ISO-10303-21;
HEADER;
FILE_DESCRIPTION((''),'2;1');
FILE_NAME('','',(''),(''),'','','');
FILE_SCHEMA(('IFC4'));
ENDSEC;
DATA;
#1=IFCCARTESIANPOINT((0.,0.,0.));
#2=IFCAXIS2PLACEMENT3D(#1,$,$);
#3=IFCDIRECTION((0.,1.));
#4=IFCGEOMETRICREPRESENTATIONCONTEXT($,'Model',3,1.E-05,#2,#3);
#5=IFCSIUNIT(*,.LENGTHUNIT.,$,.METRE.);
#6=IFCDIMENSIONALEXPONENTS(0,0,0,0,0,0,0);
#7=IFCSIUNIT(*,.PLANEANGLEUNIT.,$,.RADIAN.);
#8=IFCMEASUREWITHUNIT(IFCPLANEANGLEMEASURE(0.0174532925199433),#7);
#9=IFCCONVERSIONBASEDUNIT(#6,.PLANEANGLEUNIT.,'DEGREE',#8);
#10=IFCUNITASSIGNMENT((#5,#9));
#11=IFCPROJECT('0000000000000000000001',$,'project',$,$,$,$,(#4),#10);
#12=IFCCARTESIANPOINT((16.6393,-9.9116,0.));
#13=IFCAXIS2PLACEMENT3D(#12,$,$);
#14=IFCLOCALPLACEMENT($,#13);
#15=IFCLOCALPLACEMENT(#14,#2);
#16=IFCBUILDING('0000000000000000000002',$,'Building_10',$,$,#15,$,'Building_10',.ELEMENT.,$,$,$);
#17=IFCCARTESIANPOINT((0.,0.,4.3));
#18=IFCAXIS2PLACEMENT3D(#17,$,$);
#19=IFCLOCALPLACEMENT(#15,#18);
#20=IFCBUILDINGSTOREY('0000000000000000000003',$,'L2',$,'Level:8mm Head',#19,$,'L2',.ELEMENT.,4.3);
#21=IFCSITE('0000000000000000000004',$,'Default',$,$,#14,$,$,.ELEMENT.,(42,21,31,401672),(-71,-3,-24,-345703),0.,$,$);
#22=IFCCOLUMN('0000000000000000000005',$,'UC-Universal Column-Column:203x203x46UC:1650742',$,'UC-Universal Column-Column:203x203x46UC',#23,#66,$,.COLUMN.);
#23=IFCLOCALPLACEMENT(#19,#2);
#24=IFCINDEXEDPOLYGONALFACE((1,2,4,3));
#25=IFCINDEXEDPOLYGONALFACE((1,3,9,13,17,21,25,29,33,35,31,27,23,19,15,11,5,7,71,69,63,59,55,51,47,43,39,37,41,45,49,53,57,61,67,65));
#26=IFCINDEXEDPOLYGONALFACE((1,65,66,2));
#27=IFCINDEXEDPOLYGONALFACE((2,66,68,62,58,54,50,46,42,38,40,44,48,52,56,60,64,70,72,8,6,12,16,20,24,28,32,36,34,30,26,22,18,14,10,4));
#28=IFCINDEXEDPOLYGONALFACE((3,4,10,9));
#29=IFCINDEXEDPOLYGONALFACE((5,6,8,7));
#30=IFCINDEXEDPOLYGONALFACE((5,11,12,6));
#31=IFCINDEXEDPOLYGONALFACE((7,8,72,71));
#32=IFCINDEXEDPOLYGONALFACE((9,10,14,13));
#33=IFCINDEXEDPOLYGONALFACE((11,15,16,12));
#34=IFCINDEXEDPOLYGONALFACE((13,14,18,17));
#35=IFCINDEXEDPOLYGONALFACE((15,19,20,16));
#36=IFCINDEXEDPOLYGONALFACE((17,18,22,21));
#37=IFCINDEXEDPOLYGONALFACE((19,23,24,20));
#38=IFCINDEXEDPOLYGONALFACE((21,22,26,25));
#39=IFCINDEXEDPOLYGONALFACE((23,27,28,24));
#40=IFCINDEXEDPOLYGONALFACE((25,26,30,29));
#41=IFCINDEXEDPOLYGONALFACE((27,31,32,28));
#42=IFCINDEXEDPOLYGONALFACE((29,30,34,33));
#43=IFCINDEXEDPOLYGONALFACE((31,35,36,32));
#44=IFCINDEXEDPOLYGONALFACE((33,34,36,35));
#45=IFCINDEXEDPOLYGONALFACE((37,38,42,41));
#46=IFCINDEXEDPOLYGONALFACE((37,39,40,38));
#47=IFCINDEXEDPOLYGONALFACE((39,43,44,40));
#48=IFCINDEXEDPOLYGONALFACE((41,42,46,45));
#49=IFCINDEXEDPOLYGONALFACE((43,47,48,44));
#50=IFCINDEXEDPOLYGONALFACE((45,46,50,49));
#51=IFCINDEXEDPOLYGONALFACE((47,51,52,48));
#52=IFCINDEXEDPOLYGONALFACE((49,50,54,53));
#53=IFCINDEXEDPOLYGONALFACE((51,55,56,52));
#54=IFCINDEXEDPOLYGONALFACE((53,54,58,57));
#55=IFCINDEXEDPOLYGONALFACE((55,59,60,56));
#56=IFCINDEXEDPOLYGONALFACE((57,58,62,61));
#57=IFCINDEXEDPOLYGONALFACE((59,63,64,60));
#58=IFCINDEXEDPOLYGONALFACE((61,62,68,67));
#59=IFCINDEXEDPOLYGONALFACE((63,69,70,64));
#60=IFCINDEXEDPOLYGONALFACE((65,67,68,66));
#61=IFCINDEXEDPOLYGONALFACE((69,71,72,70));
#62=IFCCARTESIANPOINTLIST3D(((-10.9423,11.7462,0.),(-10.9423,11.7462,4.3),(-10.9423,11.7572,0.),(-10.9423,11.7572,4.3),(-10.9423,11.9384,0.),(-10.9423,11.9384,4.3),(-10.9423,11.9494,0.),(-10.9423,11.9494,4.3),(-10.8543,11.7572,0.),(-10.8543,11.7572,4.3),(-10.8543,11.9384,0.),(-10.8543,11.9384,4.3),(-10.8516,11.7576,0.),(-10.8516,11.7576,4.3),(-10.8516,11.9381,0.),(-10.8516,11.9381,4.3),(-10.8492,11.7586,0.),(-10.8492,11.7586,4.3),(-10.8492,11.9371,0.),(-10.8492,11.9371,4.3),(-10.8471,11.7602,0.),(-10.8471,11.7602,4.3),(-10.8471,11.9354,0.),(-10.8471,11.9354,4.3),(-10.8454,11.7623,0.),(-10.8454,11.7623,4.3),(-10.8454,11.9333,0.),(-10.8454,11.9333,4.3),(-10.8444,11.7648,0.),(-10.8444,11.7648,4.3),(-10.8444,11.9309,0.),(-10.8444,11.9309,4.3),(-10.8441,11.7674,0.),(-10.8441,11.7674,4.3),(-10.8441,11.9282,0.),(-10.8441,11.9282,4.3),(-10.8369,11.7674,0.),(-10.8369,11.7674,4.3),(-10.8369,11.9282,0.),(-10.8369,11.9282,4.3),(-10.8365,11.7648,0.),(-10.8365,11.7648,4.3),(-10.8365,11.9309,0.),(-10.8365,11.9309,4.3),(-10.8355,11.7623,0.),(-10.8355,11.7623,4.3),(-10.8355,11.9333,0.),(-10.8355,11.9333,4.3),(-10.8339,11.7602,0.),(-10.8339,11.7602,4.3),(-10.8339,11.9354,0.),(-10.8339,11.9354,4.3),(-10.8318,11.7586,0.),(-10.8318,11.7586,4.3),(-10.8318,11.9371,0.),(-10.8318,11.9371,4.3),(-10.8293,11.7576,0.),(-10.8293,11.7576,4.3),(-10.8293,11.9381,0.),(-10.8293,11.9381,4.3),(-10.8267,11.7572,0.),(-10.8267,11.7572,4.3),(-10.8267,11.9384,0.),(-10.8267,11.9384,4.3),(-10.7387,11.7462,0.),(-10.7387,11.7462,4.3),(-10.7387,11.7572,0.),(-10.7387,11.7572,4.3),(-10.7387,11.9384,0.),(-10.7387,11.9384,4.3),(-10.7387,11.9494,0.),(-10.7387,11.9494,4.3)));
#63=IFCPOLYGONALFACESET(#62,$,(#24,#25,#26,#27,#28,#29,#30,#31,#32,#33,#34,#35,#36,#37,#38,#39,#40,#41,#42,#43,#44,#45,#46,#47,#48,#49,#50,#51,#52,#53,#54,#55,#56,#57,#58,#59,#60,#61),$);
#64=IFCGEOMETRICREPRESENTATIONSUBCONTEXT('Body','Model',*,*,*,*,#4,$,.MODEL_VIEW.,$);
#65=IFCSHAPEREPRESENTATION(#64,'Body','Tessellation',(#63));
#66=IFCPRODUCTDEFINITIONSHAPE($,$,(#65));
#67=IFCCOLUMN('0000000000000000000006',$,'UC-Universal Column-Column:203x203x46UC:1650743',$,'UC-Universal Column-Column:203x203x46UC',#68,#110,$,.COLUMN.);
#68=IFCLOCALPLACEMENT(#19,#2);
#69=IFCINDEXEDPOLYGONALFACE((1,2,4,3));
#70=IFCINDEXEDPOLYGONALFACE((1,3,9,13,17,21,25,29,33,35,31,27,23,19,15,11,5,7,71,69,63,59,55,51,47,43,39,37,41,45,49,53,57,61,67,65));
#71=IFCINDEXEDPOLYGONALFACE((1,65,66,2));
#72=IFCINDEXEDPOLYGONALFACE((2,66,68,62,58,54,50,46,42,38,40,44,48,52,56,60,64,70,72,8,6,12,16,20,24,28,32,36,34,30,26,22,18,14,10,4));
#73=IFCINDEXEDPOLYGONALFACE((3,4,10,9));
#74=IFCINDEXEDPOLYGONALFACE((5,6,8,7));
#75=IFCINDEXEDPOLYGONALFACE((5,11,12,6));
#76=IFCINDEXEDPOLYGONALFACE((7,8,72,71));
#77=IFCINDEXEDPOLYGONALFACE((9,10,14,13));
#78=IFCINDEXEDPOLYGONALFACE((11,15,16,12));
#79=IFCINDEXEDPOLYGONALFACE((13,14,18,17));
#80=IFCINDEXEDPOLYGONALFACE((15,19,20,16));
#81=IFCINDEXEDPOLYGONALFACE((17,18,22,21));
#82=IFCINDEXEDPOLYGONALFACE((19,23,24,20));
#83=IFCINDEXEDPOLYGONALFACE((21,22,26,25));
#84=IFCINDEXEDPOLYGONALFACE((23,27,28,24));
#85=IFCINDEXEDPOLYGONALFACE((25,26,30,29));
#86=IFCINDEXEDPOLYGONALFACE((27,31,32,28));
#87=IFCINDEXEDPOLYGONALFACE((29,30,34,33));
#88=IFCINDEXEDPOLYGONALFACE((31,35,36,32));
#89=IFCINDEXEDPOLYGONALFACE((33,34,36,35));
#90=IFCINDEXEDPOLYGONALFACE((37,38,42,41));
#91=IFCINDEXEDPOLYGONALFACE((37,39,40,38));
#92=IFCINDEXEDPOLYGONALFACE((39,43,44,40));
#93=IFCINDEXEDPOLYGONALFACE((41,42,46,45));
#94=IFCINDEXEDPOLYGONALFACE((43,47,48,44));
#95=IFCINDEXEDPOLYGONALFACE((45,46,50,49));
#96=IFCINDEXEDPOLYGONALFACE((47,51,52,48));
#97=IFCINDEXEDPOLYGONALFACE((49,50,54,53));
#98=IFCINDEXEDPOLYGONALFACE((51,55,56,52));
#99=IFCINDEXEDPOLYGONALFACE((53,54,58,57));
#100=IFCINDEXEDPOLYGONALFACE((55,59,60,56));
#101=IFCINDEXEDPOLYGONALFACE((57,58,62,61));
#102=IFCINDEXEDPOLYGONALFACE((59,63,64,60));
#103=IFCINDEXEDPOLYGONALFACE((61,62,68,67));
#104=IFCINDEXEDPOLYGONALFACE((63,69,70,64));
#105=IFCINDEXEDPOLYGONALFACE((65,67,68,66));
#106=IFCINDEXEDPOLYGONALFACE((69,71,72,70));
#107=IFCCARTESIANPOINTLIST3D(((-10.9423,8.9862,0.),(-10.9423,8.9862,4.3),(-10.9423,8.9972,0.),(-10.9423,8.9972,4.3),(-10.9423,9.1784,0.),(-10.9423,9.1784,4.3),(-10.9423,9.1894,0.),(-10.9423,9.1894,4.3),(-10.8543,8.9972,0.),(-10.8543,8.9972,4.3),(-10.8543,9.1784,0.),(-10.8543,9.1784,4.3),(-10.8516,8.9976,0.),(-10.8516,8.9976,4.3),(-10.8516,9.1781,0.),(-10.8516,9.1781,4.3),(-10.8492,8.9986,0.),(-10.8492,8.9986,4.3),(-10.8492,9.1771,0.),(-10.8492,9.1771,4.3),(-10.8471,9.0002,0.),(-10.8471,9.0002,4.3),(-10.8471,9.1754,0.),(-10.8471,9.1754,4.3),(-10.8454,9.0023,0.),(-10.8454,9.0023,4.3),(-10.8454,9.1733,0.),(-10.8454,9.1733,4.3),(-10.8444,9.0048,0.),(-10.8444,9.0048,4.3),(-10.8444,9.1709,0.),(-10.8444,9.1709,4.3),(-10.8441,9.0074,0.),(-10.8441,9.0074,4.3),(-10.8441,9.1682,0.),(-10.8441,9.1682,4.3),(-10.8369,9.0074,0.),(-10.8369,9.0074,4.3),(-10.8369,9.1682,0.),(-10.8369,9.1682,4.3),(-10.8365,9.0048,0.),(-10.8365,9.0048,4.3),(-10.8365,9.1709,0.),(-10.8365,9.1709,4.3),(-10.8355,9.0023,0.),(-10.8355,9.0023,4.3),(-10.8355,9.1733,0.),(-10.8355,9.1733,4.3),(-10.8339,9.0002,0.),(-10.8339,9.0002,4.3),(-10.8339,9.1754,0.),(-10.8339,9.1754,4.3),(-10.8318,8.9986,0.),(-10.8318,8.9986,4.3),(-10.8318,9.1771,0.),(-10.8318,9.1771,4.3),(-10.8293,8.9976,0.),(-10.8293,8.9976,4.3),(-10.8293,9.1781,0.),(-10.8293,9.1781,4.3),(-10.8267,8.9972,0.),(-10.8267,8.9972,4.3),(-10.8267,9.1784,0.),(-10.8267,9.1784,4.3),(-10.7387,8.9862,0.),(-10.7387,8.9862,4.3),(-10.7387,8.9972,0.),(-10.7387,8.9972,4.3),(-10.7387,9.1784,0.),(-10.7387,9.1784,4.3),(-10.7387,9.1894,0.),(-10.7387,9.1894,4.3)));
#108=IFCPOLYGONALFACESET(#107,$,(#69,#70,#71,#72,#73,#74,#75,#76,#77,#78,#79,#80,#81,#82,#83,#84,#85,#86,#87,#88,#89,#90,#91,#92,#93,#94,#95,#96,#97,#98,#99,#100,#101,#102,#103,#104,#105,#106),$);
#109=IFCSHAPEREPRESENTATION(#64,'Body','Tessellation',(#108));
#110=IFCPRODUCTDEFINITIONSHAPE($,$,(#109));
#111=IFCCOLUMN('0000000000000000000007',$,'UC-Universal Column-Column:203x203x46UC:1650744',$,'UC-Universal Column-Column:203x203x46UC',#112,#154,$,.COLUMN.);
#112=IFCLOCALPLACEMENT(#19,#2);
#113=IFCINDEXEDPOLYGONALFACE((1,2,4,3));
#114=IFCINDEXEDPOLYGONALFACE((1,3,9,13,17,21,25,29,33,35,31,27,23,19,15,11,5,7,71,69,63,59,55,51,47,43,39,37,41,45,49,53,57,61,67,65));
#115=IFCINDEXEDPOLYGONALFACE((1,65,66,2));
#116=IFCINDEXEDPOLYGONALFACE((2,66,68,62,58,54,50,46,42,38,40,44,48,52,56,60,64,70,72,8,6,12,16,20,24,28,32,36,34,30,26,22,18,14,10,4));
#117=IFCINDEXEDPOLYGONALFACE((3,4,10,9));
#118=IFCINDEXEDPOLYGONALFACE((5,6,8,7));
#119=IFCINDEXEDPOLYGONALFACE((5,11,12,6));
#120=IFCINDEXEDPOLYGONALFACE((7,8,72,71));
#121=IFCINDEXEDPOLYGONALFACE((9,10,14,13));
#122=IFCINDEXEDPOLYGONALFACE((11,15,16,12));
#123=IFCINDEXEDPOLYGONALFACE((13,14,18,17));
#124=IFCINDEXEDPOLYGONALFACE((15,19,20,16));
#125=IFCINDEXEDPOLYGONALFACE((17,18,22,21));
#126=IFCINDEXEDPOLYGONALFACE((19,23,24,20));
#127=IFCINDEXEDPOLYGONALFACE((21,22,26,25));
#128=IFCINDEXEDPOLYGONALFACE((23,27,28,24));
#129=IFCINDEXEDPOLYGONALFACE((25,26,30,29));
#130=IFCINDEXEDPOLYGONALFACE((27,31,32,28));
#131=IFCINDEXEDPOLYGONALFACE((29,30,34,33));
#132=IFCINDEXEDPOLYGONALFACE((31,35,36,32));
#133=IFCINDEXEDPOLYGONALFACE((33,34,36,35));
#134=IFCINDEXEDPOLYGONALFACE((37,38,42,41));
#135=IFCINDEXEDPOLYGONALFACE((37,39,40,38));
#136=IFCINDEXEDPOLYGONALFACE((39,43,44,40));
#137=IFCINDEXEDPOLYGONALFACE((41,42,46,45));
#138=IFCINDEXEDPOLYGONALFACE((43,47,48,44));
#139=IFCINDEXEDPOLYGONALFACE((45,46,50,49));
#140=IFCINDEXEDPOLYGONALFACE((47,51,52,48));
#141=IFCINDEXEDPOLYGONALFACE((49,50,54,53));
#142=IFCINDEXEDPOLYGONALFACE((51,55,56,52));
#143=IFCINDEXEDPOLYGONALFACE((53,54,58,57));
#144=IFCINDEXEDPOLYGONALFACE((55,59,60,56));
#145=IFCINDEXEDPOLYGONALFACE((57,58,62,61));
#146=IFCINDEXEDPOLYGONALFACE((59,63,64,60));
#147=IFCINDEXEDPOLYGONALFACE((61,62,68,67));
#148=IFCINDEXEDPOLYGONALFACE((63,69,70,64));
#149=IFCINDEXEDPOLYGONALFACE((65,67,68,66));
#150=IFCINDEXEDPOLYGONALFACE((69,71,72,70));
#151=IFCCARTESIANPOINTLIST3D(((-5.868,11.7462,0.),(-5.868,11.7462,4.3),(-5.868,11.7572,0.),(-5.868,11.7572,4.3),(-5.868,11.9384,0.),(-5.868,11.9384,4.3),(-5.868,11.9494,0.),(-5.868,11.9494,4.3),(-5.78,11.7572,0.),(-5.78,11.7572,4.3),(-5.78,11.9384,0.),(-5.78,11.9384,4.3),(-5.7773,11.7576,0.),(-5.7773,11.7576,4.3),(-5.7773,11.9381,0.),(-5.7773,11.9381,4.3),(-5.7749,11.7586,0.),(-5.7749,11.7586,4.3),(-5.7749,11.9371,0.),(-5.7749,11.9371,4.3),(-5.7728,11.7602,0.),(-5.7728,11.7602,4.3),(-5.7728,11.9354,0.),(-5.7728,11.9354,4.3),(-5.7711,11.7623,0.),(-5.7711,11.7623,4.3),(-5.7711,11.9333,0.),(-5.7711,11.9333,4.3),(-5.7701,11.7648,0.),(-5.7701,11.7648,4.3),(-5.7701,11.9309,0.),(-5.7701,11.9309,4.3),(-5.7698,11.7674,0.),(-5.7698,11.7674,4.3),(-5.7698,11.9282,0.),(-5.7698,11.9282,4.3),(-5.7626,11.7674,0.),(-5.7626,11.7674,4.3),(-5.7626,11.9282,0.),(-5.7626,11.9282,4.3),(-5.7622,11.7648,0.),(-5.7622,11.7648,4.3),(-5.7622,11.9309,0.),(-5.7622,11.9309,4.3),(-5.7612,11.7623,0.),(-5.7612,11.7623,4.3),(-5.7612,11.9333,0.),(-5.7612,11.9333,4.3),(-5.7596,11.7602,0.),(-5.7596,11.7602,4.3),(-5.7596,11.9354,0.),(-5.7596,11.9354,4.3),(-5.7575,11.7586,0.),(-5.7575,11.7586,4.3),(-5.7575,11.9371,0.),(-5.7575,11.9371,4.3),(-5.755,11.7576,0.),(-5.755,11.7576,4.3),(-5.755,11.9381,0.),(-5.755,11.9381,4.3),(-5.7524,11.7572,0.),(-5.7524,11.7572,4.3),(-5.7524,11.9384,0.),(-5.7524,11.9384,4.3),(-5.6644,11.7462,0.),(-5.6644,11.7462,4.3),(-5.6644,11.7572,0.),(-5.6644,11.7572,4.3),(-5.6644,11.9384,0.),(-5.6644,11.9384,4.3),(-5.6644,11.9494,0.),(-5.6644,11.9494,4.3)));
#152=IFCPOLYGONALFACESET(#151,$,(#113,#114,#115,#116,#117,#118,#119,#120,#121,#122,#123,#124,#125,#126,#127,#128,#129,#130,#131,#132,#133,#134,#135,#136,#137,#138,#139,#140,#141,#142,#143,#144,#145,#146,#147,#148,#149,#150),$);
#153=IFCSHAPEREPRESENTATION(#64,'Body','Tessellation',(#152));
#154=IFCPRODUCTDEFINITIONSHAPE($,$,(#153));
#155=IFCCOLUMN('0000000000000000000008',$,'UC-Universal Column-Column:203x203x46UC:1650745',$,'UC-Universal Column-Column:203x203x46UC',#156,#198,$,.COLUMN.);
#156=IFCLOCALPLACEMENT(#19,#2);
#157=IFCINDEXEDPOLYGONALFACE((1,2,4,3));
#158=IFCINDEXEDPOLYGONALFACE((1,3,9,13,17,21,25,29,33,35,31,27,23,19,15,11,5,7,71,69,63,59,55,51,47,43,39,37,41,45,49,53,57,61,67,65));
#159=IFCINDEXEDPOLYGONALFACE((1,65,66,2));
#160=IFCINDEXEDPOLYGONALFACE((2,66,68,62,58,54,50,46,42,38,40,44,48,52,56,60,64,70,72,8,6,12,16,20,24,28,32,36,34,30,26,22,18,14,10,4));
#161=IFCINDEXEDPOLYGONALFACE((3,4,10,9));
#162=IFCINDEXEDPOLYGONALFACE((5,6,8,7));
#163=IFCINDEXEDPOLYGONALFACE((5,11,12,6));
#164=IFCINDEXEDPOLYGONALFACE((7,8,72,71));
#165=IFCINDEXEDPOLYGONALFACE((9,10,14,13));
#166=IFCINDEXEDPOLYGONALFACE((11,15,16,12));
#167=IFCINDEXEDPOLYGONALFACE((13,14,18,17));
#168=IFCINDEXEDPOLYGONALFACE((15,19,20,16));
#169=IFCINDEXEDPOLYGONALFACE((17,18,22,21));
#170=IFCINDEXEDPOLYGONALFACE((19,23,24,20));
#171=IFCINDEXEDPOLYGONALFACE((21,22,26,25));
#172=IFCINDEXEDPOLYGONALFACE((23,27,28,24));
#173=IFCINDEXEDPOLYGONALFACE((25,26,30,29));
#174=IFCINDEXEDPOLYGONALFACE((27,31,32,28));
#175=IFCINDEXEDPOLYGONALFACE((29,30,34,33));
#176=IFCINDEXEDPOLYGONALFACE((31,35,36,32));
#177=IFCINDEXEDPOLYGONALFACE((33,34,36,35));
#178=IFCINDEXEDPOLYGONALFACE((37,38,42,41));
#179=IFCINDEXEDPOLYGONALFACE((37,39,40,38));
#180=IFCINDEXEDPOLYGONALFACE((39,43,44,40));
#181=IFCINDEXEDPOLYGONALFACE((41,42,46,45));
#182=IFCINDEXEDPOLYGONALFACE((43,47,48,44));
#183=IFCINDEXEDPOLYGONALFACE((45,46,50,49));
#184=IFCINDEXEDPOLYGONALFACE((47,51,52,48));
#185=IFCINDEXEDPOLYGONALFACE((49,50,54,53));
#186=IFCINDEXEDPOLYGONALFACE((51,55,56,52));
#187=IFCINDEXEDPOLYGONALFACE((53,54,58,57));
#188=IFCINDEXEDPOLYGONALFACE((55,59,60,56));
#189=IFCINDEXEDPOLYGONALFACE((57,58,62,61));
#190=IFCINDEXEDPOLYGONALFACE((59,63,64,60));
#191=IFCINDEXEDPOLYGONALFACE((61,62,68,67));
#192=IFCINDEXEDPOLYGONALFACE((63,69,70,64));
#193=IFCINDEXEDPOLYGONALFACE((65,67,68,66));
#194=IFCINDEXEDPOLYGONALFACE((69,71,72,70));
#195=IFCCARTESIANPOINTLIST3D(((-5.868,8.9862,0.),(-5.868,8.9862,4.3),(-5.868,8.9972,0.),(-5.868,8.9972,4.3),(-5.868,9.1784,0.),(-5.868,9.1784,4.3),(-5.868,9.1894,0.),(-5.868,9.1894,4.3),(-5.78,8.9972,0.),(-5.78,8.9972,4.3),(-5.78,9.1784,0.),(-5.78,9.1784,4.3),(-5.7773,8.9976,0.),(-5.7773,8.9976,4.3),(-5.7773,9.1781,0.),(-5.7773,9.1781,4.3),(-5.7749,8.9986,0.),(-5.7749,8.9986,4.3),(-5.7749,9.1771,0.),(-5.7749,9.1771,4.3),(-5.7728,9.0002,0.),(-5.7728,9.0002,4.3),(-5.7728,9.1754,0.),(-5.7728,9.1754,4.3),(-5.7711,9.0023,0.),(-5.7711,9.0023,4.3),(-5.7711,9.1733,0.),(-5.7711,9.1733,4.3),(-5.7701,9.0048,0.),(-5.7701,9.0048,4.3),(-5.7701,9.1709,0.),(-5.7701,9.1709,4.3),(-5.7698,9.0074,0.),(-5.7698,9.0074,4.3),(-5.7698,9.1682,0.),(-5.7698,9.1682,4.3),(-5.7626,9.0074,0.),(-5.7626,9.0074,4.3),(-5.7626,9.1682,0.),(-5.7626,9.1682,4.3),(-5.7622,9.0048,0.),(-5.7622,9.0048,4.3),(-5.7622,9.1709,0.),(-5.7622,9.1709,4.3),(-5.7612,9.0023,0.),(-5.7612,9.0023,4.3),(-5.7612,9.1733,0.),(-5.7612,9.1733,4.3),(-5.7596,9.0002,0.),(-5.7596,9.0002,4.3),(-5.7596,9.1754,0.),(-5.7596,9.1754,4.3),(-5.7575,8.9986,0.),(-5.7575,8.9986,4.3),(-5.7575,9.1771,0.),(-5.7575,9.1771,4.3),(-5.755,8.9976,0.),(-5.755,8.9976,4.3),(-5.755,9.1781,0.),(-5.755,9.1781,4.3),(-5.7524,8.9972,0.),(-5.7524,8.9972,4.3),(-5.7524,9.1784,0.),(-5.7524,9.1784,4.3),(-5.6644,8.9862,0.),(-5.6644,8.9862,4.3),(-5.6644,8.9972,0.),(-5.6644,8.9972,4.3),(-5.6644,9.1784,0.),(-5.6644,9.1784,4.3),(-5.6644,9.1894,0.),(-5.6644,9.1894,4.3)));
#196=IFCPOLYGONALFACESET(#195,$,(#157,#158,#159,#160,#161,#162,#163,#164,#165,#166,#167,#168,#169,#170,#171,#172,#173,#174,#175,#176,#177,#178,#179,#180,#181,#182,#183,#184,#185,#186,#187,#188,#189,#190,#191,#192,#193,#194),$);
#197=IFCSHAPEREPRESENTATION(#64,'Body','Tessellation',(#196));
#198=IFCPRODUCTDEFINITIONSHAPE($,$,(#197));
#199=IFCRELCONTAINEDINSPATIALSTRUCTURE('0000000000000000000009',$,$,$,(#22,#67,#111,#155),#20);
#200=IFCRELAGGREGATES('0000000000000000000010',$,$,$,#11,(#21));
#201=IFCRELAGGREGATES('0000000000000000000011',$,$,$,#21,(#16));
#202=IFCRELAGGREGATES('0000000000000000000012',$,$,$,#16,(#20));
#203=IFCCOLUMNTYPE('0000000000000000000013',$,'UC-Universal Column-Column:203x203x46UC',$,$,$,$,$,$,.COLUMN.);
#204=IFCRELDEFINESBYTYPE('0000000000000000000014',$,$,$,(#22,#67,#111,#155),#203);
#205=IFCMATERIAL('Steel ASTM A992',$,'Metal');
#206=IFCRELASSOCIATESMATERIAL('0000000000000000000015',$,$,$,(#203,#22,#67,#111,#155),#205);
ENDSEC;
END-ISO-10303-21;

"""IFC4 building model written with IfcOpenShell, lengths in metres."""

from ifc_helpers import new_model, entity, si_unit, converted_unit, direction, frame, origin, place, context, subcontext, project, spatial, line, arc, indexed_curve, outline, extrude, source, transform, mapped, material, type_object, type_shapes, element, save


model = new_model("IFC4")

# Units and contexts
model_context = context("Model", 3, precision=1e-05, world=origin(), true_north=direction((0.0, 1.0)))
body_context = subcontext(model_context, "Body", "Model", "MODEL_VIEW")
ifc_project = project(units=[si_unit("LENGTHUNIT", "METRE"), converted_unit("PLANEANGLEUNIT", "DEGREE", entity("IfcPlaneAngleMeasure", 0.0174532925199433), si_unit("PLANEANGLEUNIT", "RADIAN"), dimensions=[0, 0, 0, 0, 0, 0, 0])], contexts=[model_context])

# Site, building, storey
site_placement = place(None, frame((16.6393, -9.9116, 0.0)))
site = spatial("IfcSite", under=ifc_project, at=site_placement, Name="Default", CompositionType="ELEMENT", RefLatitude=(42, 21, 31, 401672), RefLongitude=(-71, -3, -24, -345703), RefElevation=0.0)
building_placement = place(site_placement, origin())
building = spatial("IfcBuilding", under=site, at=building_placement, Name="Building_10", LongName="Building_10", CompositionType="ELEMENT")
storey_placement = place(building_placement, frame((0.0, 0.0, 4.3)))
storey = spatial("IfcBuildingStorey", under=building, at=storey_placement, Name="L2", ObjectType="Level:8mm Head", LongName="L2", CompositionType="ELEMENT", Elevation=4.3)

# Columns
ifc_material_1 = material(Name="Steel ASTM A992", Category="Metal")
column_type = type_object("IfcColumnType", Name="UC-Universal Column-Column:203x203x46UC", PredefinedType="COLUMN", material=ifc_material_1)
shared_shape_1 = source(origin(), body_context, "Body", "SweptSolid", [
    extrude(outline(indexed_curve([(-0.1018, -0.1016), (0.1018, -0.1016), (0.1018, -0.0906), (0.0138, -0.0906), (0.0066, -0.0876), (0.0036, -0.0804), (0.0036, 0.0804), (0.0066, 0.0876), (0.0138, 0.0906), (0.1018, 0.0906), (0.1018, 0.1016), (-0.1018, 0.1016), (-0.1018, 0.0906), (-0.0138, 0.0906), (-0.0066, 0.0876), (-0.0036, 0.0804), (-0.0036, -0.0804), (-0.0066, -0.0876), (-0.0138, -0.0906), (-0.1018, -0.0906)], segments=[line(1, 2, 3, 4), arc(4, 5, 6), line(6, 7), arc(7, 8, 9), line(9, 10, 11, 12, 13, 14), arc(14, 15, 16), line(16, 17), arc(17, 18, 19), line(19, 20, 1)], self_intersect=False)), frame((0.0, 0.0, 4.3), z_axis=(0.0, 0.0, 1.0), x_axis=(-1.0, 0.0, 0.0)), (0.0, 0.0, 1.0), 4.3),
])
type_shapes(column_type, [shared_shape_1])
for number, where, name in (
    (1, (-10.8405, 11.8478, -4.3), "UC-Universal Column-Column:203x203x46UC:1650742"),
    (2, (-10.8405, 9.0878, -4.3), "UC-Universal Column-Column:203x203x46UC:1650743"),
    (3, (-5.7662, 11.8478, -4.3), "UC-Universal Column-Column:203x203x46UC:1650744"),
    (4, (-5.7662, 9.0878, -4.3), "UC-Universal Column-Column:203x203x46UC:1650745"),
):
    element("IfcColumn", number, at=place(storey_placement, frame(where)), inside=storey, type_object=column_type, material=ifc_material_1, Name=name, ObjectType="UC-Universal Column-Column:203x203x46UC", PredefinedType="COLUMN", context=body_context, shape_type="MappedRepresentation", body=[
        mapped(shared_shape_1, transform((0.0, 0.0, 0.0), scale=1.0)),
    ])

save(model, "model.ifc")
